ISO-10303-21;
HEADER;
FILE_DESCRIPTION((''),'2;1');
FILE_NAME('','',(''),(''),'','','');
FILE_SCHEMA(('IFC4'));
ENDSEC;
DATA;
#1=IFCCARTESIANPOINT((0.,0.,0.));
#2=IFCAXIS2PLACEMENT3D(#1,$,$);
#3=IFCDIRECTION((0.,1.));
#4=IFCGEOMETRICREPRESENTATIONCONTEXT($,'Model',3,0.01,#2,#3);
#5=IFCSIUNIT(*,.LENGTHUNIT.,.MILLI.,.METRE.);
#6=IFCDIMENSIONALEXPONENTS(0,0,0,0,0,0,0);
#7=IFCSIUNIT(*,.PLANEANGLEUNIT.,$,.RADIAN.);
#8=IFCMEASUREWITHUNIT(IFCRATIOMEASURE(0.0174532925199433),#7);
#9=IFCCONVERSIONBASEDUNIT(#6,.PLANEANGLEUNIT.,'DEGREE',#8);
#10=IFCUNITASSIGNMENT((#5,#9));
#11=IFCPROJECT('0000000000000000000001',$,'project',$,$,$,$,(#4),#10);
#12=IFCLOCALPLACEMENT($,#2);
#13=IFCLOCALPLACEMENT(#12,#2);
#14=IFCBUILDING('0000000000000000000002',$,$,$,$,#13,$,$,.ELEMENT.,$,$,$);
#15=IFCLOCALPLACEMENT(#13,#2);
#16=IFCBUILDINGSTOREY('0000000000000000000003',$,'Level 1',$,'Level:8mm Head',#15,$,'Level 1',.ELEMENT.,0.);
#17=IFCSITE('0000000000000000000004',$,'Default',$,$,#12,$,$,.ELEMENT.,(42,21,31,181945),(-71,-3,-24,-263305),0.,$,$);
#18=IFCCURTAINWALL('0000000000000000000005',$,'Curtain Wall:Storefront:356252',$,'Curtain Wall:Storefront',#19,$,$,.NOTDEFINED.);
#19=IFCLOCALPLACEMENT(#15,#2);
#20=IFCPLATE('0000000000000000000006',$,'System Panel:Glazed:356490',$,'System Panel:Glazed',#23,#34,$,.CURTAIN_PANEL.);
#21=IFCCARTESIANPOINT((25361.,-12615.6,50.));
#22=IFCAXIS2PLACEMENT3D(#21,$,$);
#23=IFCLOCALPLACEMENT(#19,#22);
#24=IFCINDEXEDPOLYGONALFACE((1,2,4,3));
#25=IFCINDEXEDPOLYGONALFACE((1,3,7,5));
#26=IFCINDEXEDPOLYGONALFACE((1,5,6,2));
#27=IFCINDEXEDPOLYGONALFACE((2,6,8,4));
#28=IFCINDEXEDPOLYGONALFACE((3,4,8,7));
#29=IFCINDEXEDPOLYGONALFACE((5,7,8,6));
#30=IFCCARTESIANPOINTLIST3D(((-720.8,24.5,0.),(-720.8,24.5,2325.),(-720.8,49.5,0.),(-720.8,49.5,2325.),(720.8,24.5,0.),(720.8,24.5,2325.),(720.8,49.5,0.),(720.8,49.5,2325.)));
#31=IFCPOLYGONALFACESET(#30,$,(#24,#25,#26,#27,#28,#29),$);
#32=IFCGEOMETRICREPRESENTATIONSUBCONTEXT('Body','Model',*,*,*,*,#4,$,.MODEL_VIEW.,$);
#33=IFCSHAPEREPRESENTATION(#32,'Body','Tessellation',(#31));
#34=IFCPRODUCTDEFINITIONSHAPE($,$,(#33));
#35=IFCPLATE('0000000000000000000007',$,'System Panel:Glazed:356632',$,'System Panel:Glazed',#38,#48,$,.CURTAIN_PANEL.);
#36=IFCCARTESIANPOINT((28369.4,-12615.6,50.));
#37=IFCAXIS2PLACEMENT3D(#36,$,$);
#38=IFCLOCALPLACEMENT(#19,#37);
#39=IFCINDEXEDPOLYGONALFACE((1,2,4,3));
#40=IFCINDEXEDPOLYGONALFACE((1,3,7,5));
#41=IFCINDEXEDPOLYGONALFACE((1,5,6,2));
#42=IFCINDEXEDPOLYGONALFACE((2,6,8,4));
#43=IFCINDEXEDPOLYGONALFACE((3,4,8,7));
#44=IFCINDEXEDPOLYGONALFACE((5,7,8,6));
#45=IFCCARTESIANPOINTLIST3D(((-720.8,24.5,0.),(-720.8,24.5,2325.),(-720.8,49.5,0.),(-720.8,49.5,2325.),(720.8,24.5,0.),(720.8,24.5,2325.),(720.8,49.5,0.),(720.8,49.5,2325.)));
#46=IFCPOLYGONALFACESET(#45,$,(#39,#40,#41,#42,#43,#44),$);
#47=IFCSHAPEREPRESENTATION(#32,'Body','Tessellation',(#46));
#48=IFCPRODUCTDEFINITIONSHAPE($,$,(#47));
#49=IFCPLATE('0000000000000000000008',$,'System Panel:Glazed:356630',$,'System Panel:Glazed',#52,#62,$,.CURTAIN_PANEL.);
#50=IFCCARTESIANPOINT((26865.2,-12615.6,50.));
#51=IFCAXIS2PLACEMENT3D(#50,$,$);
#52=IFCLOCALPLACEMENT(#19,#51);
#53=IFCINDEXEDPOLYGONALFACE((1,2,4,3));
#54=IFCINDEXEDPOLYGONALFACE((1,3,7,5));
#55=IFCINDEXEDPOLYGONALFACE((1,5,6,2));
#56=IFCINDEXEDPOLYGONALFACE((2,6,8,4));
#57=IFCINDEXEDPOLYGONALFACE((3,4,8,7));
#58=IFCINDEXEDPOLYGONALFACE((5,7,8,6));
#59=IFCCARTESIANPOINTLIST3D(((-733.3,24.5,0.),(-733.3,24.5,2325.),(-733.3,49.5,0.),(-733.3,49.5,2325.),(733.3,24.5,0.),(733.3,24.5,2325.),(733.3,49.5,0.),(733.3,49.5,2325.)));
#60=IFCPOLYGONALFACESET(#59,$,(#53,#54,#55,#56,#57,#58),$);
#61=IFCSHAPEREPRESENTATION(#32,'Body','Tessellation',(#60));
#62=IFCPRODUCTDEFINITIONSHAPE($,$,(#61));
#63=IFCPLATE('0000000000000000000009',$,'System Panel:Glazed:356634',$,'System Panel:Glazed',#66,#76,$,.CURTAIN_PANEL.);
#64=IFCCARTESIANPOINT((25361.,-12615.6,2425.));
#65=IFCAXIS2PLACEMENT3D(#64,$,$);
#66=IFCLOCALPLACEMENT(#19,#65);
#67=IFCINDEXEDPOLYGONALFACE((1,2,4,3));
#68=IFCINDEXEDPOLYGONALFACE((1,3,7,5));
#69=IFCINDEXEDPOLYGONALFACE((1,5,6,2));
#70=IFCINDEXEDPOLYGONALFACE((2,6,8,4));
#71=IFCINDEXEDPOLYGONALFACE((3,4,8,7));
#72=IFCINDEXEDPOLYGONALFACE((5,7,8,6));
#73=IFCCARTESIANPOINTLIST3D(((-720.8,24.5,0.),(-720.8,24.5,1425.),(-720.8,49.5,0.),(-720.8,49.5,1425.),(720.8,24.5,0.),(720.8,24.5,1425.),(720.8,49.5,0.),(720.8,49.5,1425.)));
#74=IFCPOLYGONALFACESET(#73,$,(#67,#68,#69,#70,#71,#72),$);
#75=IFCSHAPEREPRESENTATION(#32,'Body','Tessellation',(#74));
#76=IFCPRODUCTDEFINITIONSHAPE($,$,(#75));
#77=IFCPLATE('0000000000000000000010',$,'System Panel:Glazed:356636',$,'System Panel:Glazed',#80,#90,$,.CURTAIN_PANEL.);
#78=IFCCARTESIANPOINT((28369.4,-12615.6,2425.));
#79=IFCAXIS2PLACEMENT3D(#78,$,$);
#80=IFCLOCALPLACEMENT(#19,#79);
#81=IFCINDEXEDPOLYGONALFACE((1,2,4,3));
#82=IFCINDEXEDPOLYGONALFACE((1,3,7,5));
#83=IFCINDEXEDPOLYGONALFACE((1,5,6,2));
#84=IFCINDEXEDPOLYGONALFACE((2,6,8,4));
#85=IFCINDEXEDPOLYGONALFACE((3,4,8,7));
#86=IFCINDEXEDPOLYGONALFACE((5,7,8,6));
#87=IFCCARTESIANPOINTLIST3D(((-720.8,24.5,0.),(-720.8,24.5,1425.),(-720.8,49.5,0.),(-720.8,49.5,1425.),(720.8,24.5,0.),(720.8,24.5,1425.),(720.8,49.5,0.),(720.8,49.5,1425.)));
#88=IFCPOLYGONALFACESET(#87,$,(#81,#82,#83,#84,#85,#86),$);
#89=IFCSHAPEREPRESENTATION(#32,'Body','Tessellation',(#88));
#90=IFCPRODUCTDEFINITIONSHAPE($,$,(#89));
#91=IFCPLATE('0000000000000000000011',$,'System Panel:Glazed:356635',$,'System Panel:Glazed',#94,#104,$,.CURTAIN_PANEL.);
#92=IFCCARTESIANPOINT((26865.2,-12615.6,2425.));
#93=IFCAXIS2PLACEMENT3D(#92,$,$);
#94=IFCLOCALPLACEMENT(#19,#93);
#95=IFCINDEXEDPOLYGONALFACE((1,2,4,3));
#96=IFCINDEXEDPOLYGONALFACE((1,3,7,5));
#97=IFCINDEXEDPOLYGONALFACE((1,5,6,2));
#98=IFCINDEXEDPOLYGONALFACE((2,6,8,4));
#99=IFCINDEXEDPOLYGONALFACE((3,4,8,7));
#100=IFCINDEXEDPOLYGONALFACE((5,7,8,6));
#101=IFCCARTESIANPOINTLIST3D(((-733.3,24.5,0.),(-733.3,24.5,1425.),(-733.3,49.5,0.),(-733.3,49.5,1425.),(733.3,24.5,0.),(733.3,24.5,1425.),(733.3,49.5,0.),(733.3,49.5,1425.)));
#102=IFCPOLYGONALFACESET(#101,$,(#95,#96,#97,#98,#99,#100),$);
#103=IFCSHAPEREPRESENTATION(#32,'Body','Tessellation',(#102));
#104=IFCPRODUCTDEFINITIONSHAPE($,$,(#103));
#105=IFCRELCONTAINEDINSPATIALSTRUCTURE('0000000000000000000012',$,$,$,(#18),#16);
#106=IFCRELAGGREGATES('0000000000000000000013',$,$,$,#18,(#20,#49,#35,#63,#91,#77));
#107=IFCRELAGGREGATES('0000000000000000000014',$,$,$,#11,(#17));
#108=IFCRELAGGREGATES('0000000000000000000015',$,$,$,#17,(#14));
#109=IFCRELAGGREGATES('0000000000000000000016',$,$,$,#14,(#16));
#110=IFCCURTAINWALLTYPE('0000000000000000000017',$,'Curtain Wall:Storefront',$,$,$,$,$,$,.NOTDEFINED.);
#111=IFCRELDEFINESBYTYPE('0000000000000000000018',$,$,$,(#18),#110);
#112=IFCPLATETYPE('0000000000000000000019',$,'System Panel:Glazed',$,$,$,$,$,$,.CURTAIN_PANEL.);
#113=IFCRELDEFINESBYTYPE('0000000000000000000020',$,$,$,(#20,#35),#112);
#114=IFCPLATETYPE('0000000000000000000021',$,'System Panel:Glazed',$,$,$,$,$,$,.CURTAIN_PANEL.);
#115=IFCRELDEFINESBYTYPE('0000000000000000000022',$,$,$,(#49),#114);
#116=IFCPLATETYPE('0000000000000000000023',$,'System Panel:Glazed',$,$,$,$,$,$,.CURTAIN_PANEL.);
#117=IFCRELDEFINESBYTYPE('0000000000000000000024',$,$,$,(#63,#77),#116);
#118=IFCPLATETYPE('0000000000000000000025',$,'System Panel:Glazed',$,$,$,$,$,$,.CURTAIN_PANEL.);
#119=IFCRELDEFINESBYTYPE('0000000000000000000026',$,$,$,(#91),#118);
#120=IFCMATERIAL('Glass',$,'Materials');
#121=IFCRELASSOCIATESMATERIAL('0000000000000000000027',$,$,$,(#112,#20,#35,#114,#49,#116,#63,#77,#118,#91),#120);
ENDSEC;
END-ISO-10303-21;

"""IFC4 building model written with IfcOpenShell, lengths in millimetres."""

from ifc_helpers import new_model, entity, si_unit, converted_unit, direction, frame, origin, place, context, subcontext, project, spatial, indexed_curve, outline, extrude, shape, source, transform, mapped, material, type_object, type_shapes, element, aggregate, save


model = new_model("IFC4")

# Units and contexts
model_context = context("Model", 3, precision=0.01, world=origin(), true_north=direction((0.0, 1.0)))
body_context = subcontext(model_context, "Body", "Model", "MODEL_VIEW")
footprint_context = subcontext(model_context, "FootPrint", "Model", "MODEL_VIEW")
ifc_project = project(units=[si_unit("LENGTHUNIT", "METRE", prefix="MILLI"), converted_unit("PLANEANGLEUNIT", "DEGREE", entity("IfcRatioMeasure", 0.0174532925199433), si_unit("PLANEANGLEUNIT", "RADIAN"), dimensions=[0, 0, 0, 0, 0, 0, 0])], contexts=[model_context])

# Site, building, storey
site_placement = place(None, origin())
site = spatial("IfcSite", under=ifc_project, at=site_placement, Name="Default", CompositionType="ELEMENT", RefLatitude=(42, 21, 31, 181945), RefLongitude=(-71, -3, -24, -263305), RefElevation=0.0)
building_placement = place(site_placement, origin())
building = spatial("IfcBuilding", under=site, at=building_placement, CompositionType="ELEMENT")
storey_placement = place(building_placement, origin())
storey = spatial("IfcBuildingStorey", under=building, at=storey_placement, Name="Level 1", ObjectType="Level:8mm Head", LongName="Level 1", CompositionType="ELEMENT", Elevation=0.0)

# Curtain wall
curtain_wall_type_1 = type_object("IfcCurtainWallType", Name="Curtain Wall:Storefront", PredefinedType="NOTDEFINED")
curtain_wall_1_placement = place(storey_placement, origin())
curtain_wall_1 = element("IfcCurtainWall", 1, at=curtain_wall_1_placement, inside=storey, type_object=curtain_wall_type_1, Name="Curtain Wall:Storefront:356252", ObjectType="Curtain Wall:Storefront", PredefinedType="NOTDEFINED")

# Plates
ifc_material_1 = material(Name="Glass", Category="Materials")
plate_type_1 = type_object("IfcPlateType", Name="System Panel:Glazed", PredefinedType="CURTAIN_PANEL", material=ifc_material_1)
shared_shape_1 = source(origin(), body_context, "Body", "SweptSolid", [
    extrude(outline(indexed_curve([(-12.5, -720.8), (12.5, -720.8), (12.5, 720.8), (-12.5, 720.8), (-12.5, -720.8)], self_intersect=False)), frame((0.0, 37.0, 0.0), z_axis=(0.0, 0.0, 1.0), x_axis=(0.0, 1.0, 0.0)), (0.0, 0.0, 1.0), 2325.0),
])
shared_shape_2 = source(origin(), footprint_context, "FootPrint", "Curve2D", [
    entity("IfcIndexedPolyCurve", entity("IfcCartesianPointList2D", [[720.8, 24.5], [720.8, 49.5], [-720.8, 49.5], [-720.8, 24.5], [720.8, 24.5]]), None, False),
])
type_shapes(plate_type_1, [shared_shape_1, shared_shape_2])
plate_1_placement = place(curtain_wall_1_placement, frame((25361.0, -12615.6, 50.0)))
plate_1 = element("IfcPlate", 2, at=plate_1_placement, type_object=plate_type_1, material=ifc_material_1, Name="System Panel:Glazed:356490", ObjectType="System Panel:Glazed", PredefinedType="CURTAIN_PANEL", shapes=[
    shape(body_context, "Body", "MappedRepresentation", [mapped(shared_shape_1, transform((0.0, 0.0, 0.0), scale=1.0))]),
    shape(body_context, "Body", "MappedRepresentation", [mapped(shared_shape_2, transform((0.0, 0.0, 0.0), scale=1.0))]),
])
plate_2_placement = place(curtain_wall_1_placement, frame((28369.4, -12615.6, 50.0)))
plate_2 = element("IfcPlate", 3, at=plate_2_placement, type_object=plate_type_1, material=ifc_material_1, Name="System Panel:Glazed:356632", ObjectType="System Panel:Glazed", PredefinedType="CURTAIN_PANEL", shapes=[
    shape(body_context, "Body", "MappedRepresentation", [mapped(shared_shape_1, transform((0.0, 0.0, 0.0), scale=1.0))]),
    shape(body_context, "Body", "MappedRepresentation", [mapped(shared_shape_2, transform((0.0, 0.0, 0.0), scale=1.0))]),
])
plate_type_2 = type_object("IfcPlateType", Name="System Panel:Glazed", PredefinedType="CURTAIN_PANEL", material=ifc_material_1)
shared_shape_3 = source(origin(), body_context, "Body", "SweptSolid", [
    extrude(outline(indexed_curve([(-12.5, -733.3), (12.5, -733.3), (12.5, 733.3), (-12.5, 733.3), (-12.5, -733.3)], self_intersect=False)), frame((0.0, 37.0, 0.0), z_axis=(0.0, 0.0, 1.0), x_axis=(0.0, 1.0, 0.0)), (0.0, 0.0, 1.0), 2325.0),
])
shared_shape_4 = source(origin(), footprint_context, "FootPrint", "Curve2D", [
    entity("IfcIndexedPolyCurve", entity("IfcCartesianPointList2D", [[733.3, 24.5], [733.3, 49.5], [-733.3, 49.5], [-733.3, 24.5], [733.3, 24.5]]), None, False),
])
type_shapes(plate_type_2, [shared_shape_3, shared_shape_4])
plate_3_placement = place(curtain_wall_1_placement, frame((26865.2, -12615.6, 50.0)))
plate_3 = element("IfcPlate", 4, at=plate_3_placement, type_object=plate_type_2, material=ifc_material_1, Name="System Panel:Glazed:356630", ObjectType="System Panel:Glazed", PredefinedType="CURTAIN_PANEL", shapes=[
    shape(body_context, "Body", "MappedRepresentation", [mapped(shared_shape_3, transform((0.0, 0.0, 0.0), scale=1.0))]),
    shape(body_context, "Body", "MappedRepresentation", [mapped(shared_shape_4, transform((0.0, 0.0, 0.0), scale=1.0))]),
])
plate_type_3 = type_object("IfcPlateType", Name="System Panel:Glazed", PredefinedType="CURTAIN_PANEL", material=ifc_material_1)
shared_shape_5 = source(origin(), body_context, "Body", "SweptSolid", [
    extrude(outline(indexed_curve([(-12.5, -720.8), (12.5, -720.8), (12.5, 720.8), (-12.5, 720.8), (-12.5, -720.8)], self_intersect=False)), frame((0.0, 37.0, 0.0), z_axis=(0.0, 0.0, 1.0), x_axis=(0.0, 1.0, 0.0)), (0.0, 0.0, 1.0), 1425.0),
])
shared_shape_6 = source(origin(), footprint_context, "FootPrint", "Curve2D", [
    entity("IfcIndexedPolyCurve", entity("IfcCartesianPointList2D", [[720.8, 24.5], [720.8, 49.5], [-720.8, 49.5], [-720.8, 24.5], [720.8, 24.5]]), None, False),
])
type_shapes(plate_type_3, [shared_shape_5, shared_shape_6])
plate_4_placement = place(curtain_wall_1_placement, frame((25361.0, -12615.6, 2425.0)))
plate_4 = element("IfcPlate", 5, at=plate_4_placement, type_object=plate_type_3, material=ifc_material_1, Name="System Panel:Glazed:356634", ObjectType="System Panel:Glazed", PredefinedType="CURTAIN_PANEL", shapes=[
    shape(body_context, "Body", "MappedRepresentation", [mapped(shared_shape_5, transform((0.0, 0.0, 0.0), scale=1.0))]),
    shape(body_context, "Body", "MappedRepresentation", [mapped(shared_shape_6, transform((0.0, 0.0, 0.0), scale=1.0))]),
])
plate_5_placement = place(curtain_wall_1_placement, frame((28369.4, -12615.6, 2425.0)))
plate_5 = element("IfcPlate", 6, at=plate_5_placement, type_object=plate_type_3, material=ifc_material_1, Name="System Panel:Glazed:356636", ObjectType="System Panel:Glazed", PredefinedType="CURTAIN_PANEL", shapes=[
    shape(body_context, "Body", "MappedRepresentation", [mapped(shared_shape_5, transform((0.0, 0.0, 0.0), scale=1.0))]),
    shape(body_context, "Body", "MappedRepresentation", [mapped(shared_shape_6, transform((0.0, 0.0, 0.0), scale=1.0))]),
])
plate_type_4 = type_object("IfcPlateType", Name="System Panel:Glazed", PredefinedType="CURTAIN_PANEL", material=ifc_material_1)
shared_shape_7 = source(origin(), body_context, "Body", "SweptSolid", [
    extrude(outline(indexed_curve([(-12.5, -733.3), (12.5, -733.3), (12.5, 733.3), (-12.5, 733.3), (-12.5, -733.3)], self_intersect=False)), frame((0.0, 37.0, 0.0), z_axis=(0.0, 0.0, 1.0), x_axis=(0.0, 1.0, 0.0)), (0.0, 0.0, 1.0), 1425.0),
])
shared_shape_8 = source(origin(), footprint_context, "FootPrint", "Curve2D", [
    entity("IfcIndexedPolyCurve", entity("IfcCartesianPointList2D", [[733.3, 24.5], [733.3, 49.5], [-733.3, 49.5], [-733.3, 24.5], [733.3, 24.5]]), None, False),
])
type_shapes(plate_type_4, [shared_shape_7, shared_shape_8])
plate_6_placement = place(curtain_wall_1_placement, frame((26865.2, -12615.6, 2425.0)))
plate_6 = element("IfcPlate", 7, at=plate_6_placement, type_object=plate_type_4, material=ifc_material_1, Name="System Panel:Glazed:356635", ObjectType="System Panel:Glazed", PredefinedType="CURTAIN_PANEL", shapes=[
    shape(body_context, "Body", "MappedRepresentation", [mapped(shared_shape_7, transform((0.0, 0.0, 0.0), scale=1.0))]),
    shape(body_context, "Body", "MappedRepresentation", [mapped(shared_shape_8, transform((0.0, 0.0, 0.0), scale=1.0))]),
])
aggregate(curtain_wall_1, [plate_1, plate_3, plate_2, plate_4, plate_6, plate_5])

save(model, "model.ifc")
